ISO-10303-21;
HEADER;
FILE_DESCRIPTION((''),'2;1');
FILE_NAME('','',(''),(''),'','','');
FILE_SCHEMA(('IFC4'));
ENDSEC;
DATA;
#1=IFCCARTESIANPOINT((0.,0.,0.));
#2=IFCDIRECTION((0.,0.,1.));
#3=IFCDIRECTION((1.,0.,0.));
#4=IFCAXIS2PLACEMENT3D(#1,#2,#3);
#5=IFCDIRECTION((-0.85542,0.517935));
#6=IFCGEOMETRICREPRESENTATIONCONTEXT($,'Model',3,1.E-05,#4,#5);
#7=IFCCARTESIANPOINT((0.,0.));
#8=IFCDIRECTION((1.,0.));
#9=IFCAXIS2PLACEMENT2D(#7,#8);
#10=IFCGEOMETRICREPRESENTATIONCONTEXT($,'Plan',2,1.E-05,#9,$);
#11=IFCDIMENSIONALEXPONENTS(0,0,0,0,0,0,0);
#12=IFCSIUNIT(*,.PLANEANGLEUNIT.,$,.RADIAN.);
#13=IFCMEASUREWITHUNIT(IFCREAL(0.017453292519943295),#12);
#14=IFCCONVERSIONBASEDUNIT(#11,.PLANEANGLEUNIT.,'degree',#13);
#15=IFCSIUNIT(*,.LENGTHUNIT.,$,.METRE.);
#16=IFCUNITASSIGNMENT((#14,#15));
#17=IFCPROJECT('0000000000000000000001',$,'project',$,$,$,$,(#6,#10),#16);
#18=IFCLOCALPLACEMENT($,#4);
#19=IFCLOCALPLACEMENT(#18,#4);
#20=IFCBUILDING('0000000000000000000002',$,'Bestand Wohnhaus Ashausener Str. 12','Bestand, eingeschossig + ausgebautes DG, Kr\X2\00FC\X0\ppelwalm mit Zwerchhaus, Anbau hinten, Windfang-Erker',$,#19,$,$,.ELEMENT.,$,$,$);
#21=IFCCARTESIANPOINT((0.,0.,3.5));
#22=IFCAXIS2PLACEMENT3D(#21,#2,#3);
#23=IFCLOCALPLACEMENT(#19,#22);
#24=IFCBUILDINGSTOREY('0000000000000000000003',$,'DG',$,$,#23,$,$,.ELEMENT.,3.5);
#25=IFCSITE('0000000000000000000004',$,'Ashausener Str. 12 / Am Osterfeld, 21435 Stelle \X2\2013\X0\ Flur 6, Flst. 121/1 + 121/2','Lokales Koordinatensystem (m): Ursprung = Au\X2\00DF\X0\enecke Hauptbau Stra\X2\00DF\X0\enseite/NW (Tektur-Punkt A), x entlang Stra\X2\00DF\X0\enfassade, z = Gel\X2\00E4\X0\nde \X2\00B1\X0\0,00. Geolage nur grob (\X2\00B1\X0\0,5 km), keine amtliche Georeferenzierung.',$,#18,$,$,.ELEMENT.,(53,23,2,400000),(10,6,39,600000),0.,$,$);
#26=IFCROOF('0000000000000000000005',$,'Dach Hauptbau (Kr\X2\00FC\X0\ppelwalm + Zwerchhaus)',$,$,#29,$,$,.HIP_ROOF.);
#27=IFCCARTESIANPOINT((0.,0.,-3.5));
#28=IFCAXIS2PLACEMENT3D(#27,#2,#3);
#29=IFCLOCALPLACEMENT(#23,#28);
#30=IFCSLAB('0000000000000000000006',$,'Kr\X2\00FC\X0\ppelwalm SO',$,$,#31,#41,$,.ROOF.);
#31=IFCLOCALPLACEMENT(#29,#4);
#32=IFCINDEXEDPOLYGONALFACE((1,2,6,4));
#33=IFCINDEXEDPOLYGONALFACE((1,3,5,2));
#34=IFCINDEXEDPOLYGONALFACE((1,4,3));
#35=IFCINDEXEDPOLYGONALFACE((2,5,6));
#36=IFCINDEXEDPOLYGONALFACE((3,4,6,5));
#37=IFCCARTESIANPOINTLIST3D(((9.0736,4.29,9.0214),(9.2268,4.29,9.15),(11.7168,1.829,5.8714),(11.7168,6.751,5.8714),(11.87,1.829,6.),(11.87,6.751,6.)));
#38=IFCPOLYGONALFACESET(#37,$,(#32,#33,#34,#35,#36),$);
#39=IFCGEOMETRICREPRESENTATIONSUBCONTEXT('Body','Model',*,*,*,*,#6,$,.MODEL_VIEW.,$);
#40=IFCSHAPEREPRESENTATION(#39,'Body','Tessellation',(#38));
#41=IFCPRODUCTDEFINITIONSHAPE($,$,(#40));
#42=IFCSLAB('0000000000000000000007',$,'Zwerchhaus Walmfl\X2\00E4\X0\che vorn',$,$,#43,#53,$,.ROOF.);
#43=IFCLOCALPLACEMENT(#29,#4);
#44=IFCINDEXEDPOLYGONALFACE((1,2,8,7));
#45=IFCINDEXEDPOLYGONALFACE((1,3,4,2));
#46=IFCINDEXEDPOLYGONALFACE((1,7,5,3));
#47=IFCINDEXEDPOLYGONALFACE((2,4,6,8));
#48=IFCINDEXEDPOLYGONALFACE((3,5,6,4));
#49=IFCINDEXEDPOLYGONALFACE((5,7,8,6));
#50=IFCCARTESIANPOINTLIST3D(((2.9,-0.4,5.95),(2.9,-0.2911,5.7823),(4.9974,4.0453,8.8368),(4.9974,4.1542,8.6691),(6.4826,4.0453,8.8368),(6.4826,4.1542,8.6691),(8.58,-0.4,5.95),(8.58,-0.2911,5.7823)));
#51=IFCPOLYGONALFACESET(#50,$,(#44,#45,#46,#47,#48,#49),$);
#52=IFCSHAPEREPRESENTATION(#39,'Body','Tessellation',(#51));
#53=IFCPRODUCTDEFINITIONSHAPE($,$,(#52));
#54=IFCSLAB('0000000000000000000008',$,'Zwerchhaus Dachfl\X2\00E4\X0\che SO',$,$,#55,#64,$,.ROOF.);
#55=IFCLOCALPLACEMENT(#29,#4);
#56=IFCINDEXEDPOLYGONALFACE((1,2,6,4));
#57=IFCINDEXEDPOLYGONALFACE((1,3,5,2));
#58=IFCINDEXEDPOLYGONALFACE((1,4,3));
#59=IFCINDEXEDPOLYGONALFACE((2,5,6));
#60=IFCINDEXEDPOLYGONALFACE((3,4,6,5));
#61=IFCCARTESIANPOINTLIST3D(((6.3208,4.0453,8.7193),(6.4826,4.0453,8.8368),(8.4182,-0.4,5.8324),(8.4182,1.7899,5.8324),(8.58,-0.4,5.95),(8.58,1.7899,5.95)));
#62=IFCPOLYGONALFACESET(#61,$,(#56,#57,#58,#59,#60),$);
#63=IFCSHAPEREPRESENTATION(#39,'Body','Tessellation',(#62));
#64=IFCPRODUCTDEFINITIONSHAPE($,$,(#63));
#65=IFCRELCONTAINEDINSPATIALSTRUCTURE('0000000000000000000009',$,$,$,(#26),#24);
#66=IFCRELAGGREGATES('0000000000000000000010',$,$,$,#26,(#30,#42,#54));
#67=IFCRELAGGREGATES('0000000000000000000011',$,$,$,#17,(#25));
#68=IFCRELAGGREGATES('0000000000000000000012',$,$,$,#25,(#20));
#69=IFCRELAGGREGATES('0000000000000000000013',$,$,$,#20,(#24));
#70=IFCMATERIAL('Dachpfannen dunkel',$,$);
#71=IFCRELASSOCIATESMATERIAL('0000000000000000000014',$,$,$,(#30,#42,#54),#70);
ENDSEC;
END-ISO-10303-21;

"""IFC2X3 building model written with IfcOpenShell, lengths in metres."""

from ifc_helpers import new_model, entity, si_unit, converted_unit, direction, frame, origin_with_axes, origin_2d_with_axis, place, context, subcontext, project, spatial, polyline, outline, extrude, material, element, aggregate, save


model = new_model("IFC2X3")

# Units and contexts
model_context = context("Model", 3, precision=1e-05, world=origin_with_axes(), true_north=direction((-0.85542, 0.517935)))
plan_context = context("Plan", 2, precision=1e-05, world=origin_2d_with_axis())
body_context = subcontext(model_context, "Body", "Model", "MODEL_VIEW")
ifc_project = project(units=[converted_unit("PLANEANGLEUNIT", "degree", entity("IfcReal", 0.017453292519943295), si_unit("PLANEANGLEUNIT", "RADIAN"), dimensions=[0, 0, 0, 0, 0, 0, 0]), si_unit("LENGTHUNIT", "METRE")], contexts=[model_context, plan_context])

# Site, building, storey
site_placement = place(None, origin_with_axes())
site = spatial("IfcSite", under=ifc_project, at=site_placement, Name="Ashausener Str. 12 / Am Osterfeld, 21435 Stelle – Flur 6, Flst. 121/1 + 121/2", Description="Lokales Koordinatensystem (m): Ursprung = Außenecke Hauptbau Straßenseite/NW (Tektur-Punkt A), x entlang Straßenfassade, z = Gelände ±0,00. Geolage nur grob (±0,5 km), keine amtliche Georeferenzierung.", CompositionType="ELEMENT", RefLatitude=(53, 23, 2, 400000), RefLongitude=(10, 6, 39, 600000), RefElevation=0.0)
building_placement = place(site_placement, origin_with_axes())
building = spatial("IfcBuilding", under=site, at=building_placement, Name="Bestand Wohnhaus Ashausener Str. 12", Description="Bestand, eingeschossig + ausgebautes DG, Krüppelwalm mit Zwerchhaus, Anbau hinten, Windfang-Erker", CompositionType="ELEMENT")
storey_placement = place(building_placement, frame((0.0, 0.0, 3.5), z_axis=(0.0, 0.0, 1.0), x_axis=(1.0, 0.0, 0.0)))
storey = spatial("IfcBuildingStorey", under=building, at=storey_placement, Name="DG", CompositionType="ELEMENT", Elevation=3.5)

# Roof, slabs
roof_placement = place(storey_placement, frame((0.0, 0.0, -3.5), z_axis=(0.0, 0.0, 1.0), x_axis=(1.0, 0.0, 0.0)))
roof = element("IfcRoof", 1, at=roof_placement, inside=storey, Name="Dach Hauptbau (Krüppelwalm + Zwerchhaus)", ShapeType="HIP_ROOF")
ifc_material_1 = material(Name="Dachpfannen dunkel")
slab_1_placement = place(roof_placement, origin_with_axes())
slab_1 = element("IfcSlab", 2, at=slab_1_placement, material=ifc_material_1, Name="Krüppelwalm SO", PredefinedType="ROOF", context=body_context, shape_type="SweptSolid", body=[
    extrude(outline(polyline([(0.0, 0.0), (4.9221, 0.0), (2.4611, 4.112), (0.0, 0.0)])), frame((11.87, 1.829, 6.0), z_axis=(0.766045, 0.0, 0.642787), x_axis=(0.0, 1.0, 0.0)), (0.0, 0.0, -1.0), 0.2),
])
slab_2_placement = place(roof_placement, origin_with_axes())
slab_2 = element("IfcSlab", 3, at=slab_2_placement, material=ifc_material_1, Name="Zwerchhaus Walmfläche vorn", PredefinedType="ROOF", context=body_context, shape_type="SweptSolid", body=[
    extrude(outline(polyline([(0.0, 0.0), (5.68, 0.0), (3.5826, 5.3004), (2.0974, 5.3004), (0.0, 0.0)])), frame((2.9, -0.4, 5.95), z_axis=(0.0, -0.54464, 0.83867), x_axis=(1.0, 0.0, 0.0)), (0.0, 0.0, -1.0), 0.2),
])
slab_3_placement = place(roof_placement, origin_with_axes())
slab_3 = element("IfcSlab", 4, at=slab_3_placement, material=ifc_material_1, Name="Zwerchhaus Dachfläche SO", PredefinedType="ROOF", context=body_context, shape_type="SweptSolid", body=[
    extrude(outline(polyline([(0.0, 0.0), (2.1899, 0.0), (4.4453, 3.5683), (0.0, 0.0)])), frame((8.58, -0.4, 5.95), z_axis=(0.809018, 0.0, 0.587784), x_axis=(0.0, 1.0, 0.0)), (0.0, 0.0, -1.0), 0.2),
])
aggregate(roof, [slab_1, slab_2, slab_3])

save(model, "model.ifc")
